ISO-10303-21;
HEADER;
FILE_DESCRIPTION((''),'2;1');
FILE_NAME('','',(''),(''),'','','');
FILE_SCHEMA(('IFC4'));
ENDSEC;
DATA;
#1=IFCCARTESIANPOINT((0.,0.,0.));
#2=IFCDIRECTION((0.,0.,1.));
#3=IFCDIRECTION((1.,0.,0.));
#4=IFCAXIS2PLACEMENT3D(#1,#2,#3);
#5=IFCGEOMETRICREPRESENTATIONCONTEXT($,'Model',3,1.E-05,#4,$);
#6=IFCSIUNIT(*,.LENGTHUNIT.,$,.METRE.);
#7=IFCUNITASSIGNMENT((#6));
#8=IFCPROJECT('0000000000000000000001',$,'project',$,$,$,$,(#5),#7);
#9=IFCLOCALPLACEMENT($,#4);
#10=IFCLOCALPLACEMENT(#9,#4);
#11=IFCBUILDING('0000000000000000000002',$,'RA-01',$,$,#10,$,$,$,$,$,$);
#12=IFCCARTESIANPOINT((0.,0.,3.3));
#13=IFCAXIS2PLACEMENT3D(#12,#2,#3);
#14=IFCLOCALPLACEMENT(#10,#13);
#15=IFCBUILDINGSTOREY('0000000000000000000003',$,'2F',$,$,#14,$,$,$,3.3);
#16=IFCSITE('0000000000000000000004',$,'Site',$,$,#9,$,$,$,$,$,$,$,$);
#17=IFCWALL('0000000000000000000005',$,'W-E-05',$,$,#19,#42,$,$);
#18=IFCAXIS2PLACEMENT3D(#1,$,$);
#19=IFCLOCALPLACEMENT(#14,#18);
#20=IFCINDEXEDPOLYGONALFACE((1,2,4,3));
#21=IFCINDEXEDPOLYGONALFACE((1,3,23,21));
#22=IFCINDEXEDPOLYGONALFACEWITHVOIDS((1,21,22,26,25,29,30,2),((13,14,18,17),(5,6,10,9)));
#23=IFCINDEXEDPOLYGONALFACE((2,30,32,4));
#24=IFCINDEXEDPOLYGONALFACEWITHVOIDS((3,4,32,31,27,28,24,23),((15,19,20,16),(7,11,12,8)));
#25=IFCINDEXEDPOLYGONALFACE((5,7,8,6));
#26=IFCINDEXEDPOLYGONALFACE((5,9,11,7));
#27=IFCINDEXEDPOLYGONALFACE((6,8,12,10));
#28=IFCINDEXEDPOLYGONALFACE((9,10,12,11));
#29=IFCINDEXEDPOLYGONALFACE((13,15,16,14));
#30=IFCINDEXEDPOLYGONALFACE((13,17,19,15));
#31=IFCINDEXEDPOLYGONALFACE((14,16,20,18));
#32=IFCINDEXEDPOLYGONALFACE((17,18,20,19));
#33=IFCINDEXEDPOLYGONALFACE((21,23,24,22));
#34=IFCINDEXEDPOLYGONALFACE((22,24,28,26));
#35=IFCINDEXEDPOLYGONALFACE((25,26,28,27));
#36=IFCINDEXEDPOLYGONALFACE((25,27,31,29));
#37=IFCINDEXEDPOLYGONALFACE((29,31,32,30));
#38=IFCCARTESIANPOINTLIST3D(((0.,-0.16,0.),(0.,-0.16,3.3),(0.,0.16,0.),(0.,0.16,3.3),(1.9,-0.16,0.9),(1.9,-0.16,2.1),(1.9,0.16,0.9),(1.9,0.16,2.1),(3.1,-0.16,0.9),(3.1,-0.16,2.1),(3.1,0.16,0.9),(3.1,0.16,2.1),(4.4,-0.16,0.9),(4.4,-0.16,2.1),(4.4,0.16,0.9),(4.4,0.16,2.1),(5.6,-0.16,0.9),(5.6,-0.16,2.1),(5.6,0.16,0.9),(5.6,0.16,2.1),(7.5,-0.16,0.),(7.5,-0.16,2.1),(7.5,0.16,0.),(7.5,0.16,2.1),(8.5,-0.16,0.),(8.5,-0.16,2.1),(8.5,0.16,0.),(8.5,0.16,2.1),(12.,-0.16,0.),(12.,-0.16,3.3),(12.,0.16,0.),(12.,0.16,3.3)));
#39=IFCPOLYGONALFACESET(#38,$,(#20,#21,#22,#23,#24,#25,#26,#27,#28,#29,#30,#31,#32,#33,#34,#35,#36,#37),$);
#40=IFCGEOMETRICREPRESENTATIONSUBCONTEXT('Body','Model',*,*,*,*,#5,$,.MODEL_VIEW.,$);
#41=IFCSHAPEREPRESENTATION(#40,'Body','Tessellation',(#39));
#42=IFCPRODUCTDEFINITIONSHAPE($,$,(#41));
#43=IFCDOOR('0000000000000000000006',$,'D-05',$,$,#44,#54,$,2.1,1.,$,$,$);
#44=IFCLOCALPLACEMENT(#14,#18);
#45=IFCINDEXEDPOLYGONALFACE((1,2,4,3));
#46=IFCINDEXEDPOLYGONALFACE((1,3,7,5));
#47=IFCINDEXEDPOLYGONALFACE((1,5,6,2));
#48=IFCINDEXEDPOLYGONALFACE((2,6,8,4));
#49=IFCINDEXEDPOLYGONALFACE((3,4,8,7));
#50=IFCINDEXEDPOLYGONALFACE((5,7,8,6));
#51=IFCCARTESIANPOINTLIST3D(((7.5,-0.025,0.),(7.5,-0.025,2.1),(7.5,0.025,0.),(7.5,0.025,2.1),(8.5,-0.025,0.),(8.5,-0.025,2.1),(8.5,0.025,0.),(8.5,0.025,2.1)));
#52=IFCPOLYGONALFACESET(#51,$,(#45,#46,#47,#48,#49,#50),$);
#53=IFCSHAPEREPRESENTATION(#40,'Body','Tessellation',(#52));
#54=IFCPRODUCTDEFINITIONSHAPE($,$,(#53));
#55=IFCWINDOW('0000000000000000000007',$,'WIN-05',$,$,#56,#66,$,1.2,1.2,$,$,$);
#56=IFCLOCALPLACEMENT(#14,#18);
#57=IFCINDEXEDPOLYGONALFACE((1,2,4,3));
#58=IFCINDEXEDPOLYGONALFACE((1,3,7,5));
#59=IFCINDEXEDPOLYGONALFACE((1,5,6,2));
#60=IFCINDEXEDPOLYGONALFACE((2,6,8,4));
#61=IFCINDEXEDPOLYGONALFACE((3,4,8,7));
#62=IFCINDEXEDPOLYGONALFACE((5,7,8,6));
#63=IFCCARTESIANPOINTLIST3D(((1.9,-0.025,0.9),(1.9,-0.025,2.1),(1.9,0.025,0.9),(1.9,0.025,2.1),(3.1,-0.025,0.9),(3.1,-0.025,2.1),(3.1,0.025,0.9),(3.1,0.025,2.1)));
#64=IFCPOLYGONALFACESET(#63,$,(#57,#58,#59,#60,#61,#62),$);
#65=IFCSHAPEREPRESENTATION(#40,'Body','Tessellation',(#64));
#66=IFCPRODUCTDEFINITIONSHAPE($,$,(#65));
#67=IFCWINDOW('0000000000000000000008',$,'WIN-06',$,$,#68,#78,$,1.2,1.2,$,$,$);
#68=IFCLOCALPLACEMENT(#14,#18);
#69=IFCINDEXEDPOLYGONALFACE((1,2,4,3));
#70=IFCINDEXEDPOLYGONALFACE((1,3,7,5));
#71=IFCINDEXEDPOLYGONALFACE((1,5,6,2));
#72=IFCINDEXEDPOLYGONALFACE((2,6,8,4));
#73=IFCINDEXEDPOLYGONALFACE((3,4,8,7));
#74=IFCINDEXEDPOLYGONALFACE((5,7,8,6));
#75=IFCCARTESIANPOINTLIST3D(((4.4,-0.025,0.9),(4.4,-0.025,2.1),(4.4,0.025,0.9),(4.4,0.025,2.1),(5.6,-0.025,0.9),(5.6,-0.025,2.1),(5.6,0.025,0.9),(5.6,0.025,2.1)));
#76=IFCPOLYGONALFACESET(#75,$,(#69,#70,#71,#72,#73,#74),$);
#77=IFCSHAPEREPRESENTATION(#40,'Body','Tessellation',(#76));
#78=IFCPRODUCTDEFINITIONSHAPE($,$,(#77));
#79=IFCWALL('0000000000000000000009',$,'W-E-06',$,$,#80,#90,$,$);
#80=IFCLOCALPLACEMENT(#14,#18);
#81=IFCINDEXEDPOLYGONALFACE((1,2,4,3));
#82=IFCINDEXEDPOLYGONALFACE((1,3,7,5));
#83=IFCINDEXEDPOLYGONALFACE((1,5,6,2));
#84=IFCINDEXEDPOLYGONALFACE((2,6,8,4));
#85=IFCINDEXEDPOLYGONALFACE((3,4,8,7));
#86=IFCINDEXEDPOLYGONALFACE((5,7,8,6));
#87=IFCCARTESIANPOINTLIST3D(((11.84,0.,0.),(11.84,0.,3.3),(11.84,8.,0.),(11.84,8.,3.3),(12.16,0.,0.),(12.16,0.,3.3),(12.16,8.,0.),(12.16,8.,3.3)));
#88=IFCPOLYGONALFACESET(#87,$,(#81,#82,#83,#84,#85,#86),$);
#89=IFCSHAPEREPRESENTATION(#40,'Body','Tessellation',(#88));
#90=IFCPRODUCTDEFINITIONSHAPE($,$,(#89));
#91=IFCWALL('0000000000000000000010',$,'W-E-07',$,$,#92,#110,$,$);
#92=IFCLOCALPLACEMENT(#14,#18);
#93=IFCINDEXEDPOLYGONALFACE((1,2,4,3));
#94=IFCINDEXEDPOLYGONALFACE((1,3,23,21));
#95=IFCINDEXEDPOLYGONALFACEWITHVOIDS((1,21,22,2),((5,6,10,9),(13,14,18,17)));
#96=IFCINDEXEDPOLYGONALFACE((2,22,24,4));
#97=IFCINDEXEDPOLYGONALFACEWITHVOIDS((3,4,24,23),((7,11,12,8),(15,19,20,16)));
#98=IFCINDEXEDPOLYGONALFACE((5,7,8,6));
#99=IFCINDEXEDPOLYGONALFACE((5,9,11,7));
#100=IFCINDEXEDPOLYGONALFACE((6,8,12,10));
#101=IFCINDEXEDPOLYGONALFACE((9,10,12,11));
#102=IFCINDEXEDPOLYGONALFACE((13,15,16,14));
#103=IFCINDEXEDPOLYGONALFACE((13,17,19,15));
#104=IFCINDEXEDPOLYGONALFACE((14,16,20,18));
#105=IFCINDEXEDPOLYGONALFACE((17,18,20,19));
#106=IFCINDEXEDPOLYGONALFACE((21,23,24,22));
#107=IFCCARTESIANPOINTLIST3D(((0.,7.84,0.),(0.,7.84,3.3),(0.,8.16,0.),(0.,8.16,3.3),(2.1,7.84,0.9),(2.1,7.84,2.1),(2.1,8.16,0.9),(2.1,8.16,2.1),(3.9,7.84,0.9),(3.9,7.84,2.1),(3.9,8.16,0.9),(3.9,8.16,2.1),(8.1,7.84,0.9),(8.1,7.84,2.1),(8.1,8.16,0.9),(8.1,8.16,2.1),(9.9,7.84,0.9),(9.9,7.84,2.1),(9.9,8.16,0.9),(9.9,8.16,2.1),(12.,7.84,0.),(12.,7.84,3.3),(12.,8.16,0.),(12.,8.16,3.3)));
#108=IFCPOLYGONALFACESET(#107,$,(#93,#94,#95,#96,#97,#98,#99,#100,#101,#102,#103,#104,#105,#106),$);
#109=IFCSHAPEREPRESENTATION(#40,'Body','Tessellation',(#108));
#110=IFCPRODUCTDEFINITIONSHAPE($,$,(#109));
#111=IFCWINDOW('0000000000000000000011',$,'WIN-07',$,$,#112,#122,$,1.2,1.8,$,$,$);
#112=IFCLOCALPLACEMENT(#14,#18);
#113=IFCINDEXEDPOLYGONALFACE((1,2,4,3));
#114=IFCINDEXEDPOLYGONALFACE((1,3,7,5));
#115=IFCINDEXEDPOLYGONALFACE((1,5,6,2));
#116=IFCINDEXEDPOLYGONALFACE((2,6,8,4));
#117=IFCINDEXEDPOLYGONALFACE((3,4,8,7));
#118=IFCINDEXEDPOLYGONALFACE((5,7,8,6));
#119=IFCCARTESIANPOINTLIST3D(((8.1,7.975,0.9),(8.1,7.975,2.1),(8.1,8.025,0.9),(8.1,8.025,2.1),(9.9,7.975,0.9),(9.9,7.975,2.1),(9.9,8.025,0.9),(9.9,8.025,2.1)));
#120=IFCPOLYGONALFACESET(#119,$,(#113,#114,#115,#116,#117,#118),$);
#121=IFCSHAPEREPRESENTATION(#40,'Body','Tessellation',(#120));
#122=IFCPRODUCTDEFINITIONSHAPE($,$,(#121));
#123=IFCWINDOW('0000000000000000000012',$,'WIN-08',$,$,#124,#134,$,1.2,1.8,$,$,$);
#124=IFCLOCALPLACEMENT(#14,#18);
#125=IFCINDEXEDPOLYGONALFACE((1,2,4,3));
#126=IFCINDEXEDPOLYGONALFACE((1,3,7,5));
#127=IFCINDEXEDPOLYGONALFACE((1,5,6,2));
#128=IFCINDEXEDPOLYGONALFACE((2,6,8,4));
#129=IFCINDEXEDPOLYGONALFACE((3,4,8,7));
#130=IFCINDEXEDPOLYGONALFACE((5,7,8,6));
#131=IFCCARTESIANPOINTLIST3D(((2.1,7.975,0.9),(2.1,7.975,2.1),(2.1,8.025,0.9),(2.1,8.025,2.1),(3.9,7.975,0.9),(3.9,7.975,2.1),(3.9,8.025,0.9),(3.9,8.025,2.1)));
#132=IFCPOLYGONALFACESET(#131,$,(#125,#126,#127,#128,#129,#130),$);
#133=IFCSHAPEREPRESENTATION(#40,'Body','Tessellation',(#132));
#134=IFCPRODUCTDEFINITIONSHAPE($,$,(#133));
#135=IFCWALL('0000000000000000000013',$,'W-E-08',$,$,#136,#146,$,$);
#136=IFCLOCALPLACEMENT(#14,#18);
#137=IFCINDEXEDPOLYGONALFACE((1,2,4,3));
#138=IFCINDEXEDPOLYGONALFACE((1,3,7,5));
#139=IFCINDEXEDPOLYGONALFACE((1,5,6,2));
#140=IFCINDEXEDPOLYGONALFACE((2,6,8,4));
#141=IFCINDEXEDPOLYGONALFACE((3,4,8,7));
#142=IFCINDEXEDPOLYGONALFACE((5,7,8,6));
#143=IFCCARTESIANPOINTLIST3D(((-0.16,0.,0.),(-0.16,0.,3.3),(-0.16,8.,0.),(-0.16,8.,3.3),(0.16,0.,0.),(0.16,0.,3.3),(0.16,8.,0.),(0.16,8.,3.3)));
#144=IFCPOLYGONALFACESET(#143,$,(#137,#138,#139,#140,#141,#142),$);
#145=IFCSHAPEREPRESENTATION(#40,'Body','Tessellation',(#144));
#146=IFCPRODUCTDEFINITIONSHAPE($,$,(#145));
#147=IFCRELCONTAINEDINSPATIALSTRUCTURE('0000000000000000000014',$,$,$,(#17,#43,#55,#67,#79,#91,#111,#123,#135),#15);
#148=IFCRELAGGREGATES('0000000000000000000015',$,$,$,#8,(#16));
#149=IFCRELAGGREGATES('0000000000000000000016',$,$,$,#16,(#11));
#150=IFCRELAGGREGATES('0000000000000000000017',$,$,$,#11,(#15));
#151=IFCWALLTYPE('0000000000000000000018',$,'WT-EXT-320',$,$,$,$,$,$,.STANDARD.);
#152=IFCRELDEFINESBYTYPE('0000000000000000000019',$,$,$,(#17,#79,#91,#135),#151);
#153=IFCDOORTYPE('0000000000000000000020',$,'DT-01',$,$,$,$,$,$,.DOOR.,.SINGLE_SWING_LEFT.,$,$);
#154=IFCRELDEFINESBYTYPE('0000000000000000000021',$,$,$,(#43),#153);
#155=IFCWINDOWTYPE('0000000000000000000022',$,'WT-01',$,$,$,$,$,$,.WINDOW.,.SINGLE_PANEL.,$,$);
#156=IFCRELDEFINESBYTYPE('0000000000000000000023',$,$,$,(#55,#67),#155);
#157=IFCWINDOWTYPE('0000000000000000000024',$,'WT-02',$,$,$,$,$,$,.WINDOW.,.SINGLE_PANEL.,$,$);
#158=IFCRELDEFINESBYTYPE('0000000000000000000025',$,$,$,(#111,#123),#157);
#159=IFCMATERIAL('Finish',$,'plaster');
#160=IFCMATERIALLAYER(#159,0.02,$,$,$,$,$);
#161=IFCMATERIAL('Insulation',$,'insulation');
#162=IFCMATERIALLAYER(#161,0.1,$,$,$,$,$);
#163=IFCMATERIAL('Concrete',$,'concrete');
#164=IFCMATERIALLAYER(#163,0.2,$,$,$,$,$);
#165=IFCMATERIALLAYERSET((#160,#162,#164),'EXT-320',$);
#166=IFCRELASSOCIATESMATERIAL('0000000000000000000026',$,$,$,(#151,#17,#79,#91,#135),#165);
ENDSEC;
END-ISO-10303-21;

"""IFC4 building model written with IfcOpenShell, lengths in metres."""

from ifc_helpers import new_model, si_unit, frame, frame_2d, origin_with_axes, origin_2d_with_axis, place, context, subcontext, project, spatial, rectangle, extrude, material, layer, layer_set, layer_usage, type_object, element, fill, save


model = new_model("IFC4")

# Units and contexts
model_context = context("Model", 3, precision=1e-05, world=origin_with_axes())
body_context = subcontext(model_context, "Body", "Model", "MODEL_VIEW")
ifc_project = project(units=[si_unit("LENGTHUNIT", "METRE")], contexts=[model_context])

# Site, building, storey
site_placement = place(None, origin_with_axes())
site = spatial("IfcSite", under=ifc_project, at=site_placement, Name="Site")
building_placement = place(site_placement, origin_with_axes())
building = spatial("IfcBuilding", under=site, at=building_placement, Name="RA-01")
storey_placement = place(building_placement, frame((0.0, 0.0, 3.3), z_axis=(0.0, 0.0, 1.0), x_axis=(1.0, 0.0, 0.0)))
storey = spatial("IfcBuildingStorey", under=building, at=storey_placement, Name="2F", Elevation=3.3)

# Shared definitions
ifc_material_1 = material(Name="Concrete", Category="concrete")

# Wall, openings, door, windows
ifc_material_2 = material(Name="Finish", Category="plaster")
ifc_layer_1 = layer(ifc_material_2, 0.02)
ifc_material_3 = material(Name="Insulation", Category="insulation")
ifc_layer_2 = layer(ifc_material_3, 0.1)
ifc_layer_3 = layer(ifc_material_1, 0.2)
ifc_layer_set_1 = layer_set([ifc_layer_1, ifc_layer_2, ifc_layer_3], Name="EXT-320")
ifc_layer_usage_1 = layer_usage(ifc_layer_set_1, "AXIS2", "POSITIVE", -0.16)
wall_type_1 = type_object("IfcWallType", Name="WT-EXT-320", PredefinedType="STANDARD", material=ifc_layer_set_1)
wall_1_placement = place(storey_placement, origin_with_axes())
wall_1 = element("IfcWall", 1, at=wall_1_placement, inside=storey, type_object=wall_type_1, material=ifc_layer_usage_1, Name="W-E-05", context=body_context, shape_type="SweptSolid", body=[
    extrude(rectangle(XDim=12.0, YDim=0.32, at=frame_2d((6.0, 0.0), x_axis=(1.0, 0.0))), origin_with_axes(), (0.0, 0.0, 1.0), 3.3),
])
opening_1_placement = place(wall_1_placement, frame((8.0, 0.0, 0.0), z_axis=(0.0, 0.0, 1.0), x_axis=(1.0, 0.0, 0.0)))
opening_1 = element("IfcOpeningElement", 2, at=opening_1_placement, cuts=wall_1, PredefinedType="OPENING", context=body_context, shape_type="SweptSolid", body=[
    extrude(rectangle(XDim=1.0, YDim=0.42, at=origin_2d_with_axis()), origin_with_axes(), (0.0, 0.0, 1.0), 2.1),
])
opening_2_placement = place(wall_1_placement, frame((2.5, 0.0, 0.9), z_axis=(0.0, 0.0, 1.0), x_axis=(1.0, 0.0, 0.0)))
opening_2 = element("IfcOpeningElement", 3, at=opening_2_placement, cuts=wall_1, PredefinedType="OPENING", context=body_context, shape_type="SweptSolid", body=[
    extrude(rectangle(XDim=1.2, YDim=0.42, at=origin_2d_with_axis()), origin_with_axes(), (0.0, 0.0, 1.0), 1.2),
])
opening_3_placement = place(wall_1_placement, frame((5.0, 0.0, 0.9), z_axis=(0.0, 0.0, 1.0), x_axis=(1.0, 0.0, 0.0)))
opening_3 = element("IfcOpeningElement", 4, at=opening_3_placement, cuts=wall_1, PredefinedType="OPENING", context=body_context, shape_type="SweptSolid", body=[
    extrude(rectangle(XDim=1.2, YDim=0.42, at=origin_2d_with_axis()), origin_with_axes(), (0.0, 0.0, 1.0), 1.2),
])
door_type_1 = type_object("IfcDoorType", Name="DT-01", OperationType="SINGLE_SWING_LEFT", PredefinedType="DOOR")
door_1_placement = place(opening_1_placement, origin_with_axes())
door_1 = element("IfcDoor", 5, at=door_1_placement, inside=storey, type_object=door_type_1, Name="D-05", OverallHeight=2.1, OverallWidth=1.0, context=body_context, shape_type="SweptSolid", body=[
    extrude(rectangle(XDim=1.0, YDim=0.05, at=origin_2d_with_axis()), origin_with_axes(), (0.0, 0.0, 1.0), 2.1),
])
fill(opening_1, door_1)
window_type_1 = type_object("IfcWindowType", Name="WT-01", PartitioningType="SINGLE_PANEL", PredefinedType="WINDOW")
window_1_placement = place(opening_2_placement, origin_with_axes())
window_1 = element("IfcWindow", 6, at=window_1_placement, inside=storey, type_object=window_type_1, Name="WIN-05", OverallHeight=1.2, OverallWidth=1.2, context=body_context, shape_type="SweptSolid", body=[
    extrude(rectangle(XDim=1.2, YDim=0.05, at=origin_2d_with_axis()), origin_with_axes(), (0.0, 0.0, 1.0), 1.2),
])
fill(opening_2, window_1)
window_2_placement = place(opening_3_placement, origin_with_axes())
window_2 = element("IfcWindow", 7, at=window_2_placement, inside=storey, type_object=window_type_1, Name="WIN-06", OverallHeight=1.2, OverallWidth=1.2, context=body_context, shape_type="SweptSolid", body=[
    extrude(rectangle(XDim=1.2, YDim=0.05, at=origin_2d_with_axis()), origin_with_axes(), (0.0, 0.0, 1.0), 1.2),
])
fill(opening_3, window_2)

# Wall
ifc_layer_usage_2 = layer_usage(ifc_layer_set_1, "AXIS2", "POSITIVE", -0.16)
wall_2_placement = place(storey_placement, frame((12.0, 0.0, 0.0), z_axis=(0.0, 0.0, 1.0), x_axis=(0.0, 1.0, 0.0)))
element("IfcWall", 8, at=wall_2_placement, inside=storey, type_object=wall_type_1, material=ifc_layer_usage_2, Name="W-E-06", context=body_context, shape_type="SweptSolid", body=[
    extrude(rectangle(XDim=8.0, YDim=0.32, at=frame_2d((4.0, 0.0), x_axis=(1.0, 0.0))), origin_with_axes(), (0.0, 0.0, 1.0), 3.3),
])

# Wall, openings, windows
ifc_layer_usage_3 = layer_usage(ifc_layer_set_1, "AXIS2", "POSITIVE", -0.16)
wall_3_placement = place(storey_placement, frame((12.0, 8.0, 0.0), z_axis=(0.0, 0.0, 1.0), x_axis=(-1.0, 0.0, 0.0)))
wall_3 = element("IfcWall", 9, at=wall_3_placement, inside=storey, type_object=wall_type_1, material=ifc_layer_usage_3, Name="W-E-07", context=body_context, shape_type="SweptSolid", body=[
    extrude(rectangle(XDim=12.0, YDim=0.32, at=frame_2d((6.0, 0.0), x_axis=(1.0, 0.0))), origin_with_axes(), (0.0, 0.0, 1.0), 3.3),
])
opening_4_placement = place(wall_3_placement, frame((3.0, 0.0, 0.9), z_axis=(0.0, 0.0, 1.0), x_axis=(1.0, 0.0, 0.0)))
opening_4 = element("IfcOpeningElement", 10, at=opening_4_placement, cuts=wall_3, PredefinedType="OPENING", context=body_context, shape_type="SweptSolid", body=[
    extrude(rectangle(XDim=1.8, YDim=0.42, at=origin_2d_with_axis()), origin_with_axes(), (0.0, 0.0, 1.0), 1.2),
])
opening_5_placement = place(wall_3_placement, frame((9.0, 0.0, 0.9), z_axis=(0.0, 0.0, 1.0), x_axis=(1.0, 0.0, 0.0)))
opening_5 = element("IfcOpeningElement", 11, at=opening_5_placement, cuts=wall_3, PredefinedType="OPENING", context=body_context, shape_type="SweptSolid", body=[
    extrude(rectangle(XDim=1.8, YDim=0.42, at=origin_2d_with_axis()), origin_with_axes(), (0.0, 0.0, 1.0), 1.2),
])
window_type_2 = type_object("IfcWindowType", Name="WT-02", PartitioningType="SINGLE_PANEL", PredefinedType="WINDOW")
window_3_placement = place(opening_4_placement, origin_with_axes())
window_3 = element("IfcWindow", 12, at=window_3_placement, inside=storey, type_object=window_type_2, Name="WIN-07", OverallHeight=1.2, OverallWidth=1.8, context=body_context, shape_type="SweptSolid", body=[
    extrude(rectangle(XDim=1.8, YDim=0.05, at=origin_2d_with_axis()), origin_with_axes(), (0.0, 0.0, 1.0), 1.2),
])
fill(opening_4, window_3)
window_4_placement = place(opening_5_placement, origin_with_axes())
window_4 = element("IfcWindow", 13, at=window_4_placement, inside=storey, type_object=window_type_2, Name="WIN-08", OverallHeight=1.2, OverallWidth=1.8, context=body_context, shape_type="SweptSolid", body=[
    extrude(rectangle(XDim=1.8, YDim=0.05, at=origin_2d_with_axis()), origin_with_axes(), (0.0, 0.0, 1.0), 1.2),
])
fill(opening_5, window_4)

# Wall
ifc_layer_usage_4 = layer_usage(ifc_layer_set_1, "AXIS2", "POSITIVE", -0.16)
wall_4_placement = place(storey_placement, frame((0.0, 8.0, 0.0), z_axis=(0.0, 0.0, 1.0), x_axis=(0.0, -1.0, 0.0)))
element("IfcWall", 14, at=wall_4_placement, inside=storey, type_object=wall_type_1, material=ifc_layer_usage_4, Name="W-E-08", context=body_context, shape_type="SweptSolid", body=[
    extrude(rectangle(XDim=8.0, YDim=0.32, at=frame_2d((4.0, 0.0), x_axis=(1.0, 0.0))), origin_with_axes(), (0.0, 0.0, 1.0), 3.3),
])

save(model, "model.ifc")
